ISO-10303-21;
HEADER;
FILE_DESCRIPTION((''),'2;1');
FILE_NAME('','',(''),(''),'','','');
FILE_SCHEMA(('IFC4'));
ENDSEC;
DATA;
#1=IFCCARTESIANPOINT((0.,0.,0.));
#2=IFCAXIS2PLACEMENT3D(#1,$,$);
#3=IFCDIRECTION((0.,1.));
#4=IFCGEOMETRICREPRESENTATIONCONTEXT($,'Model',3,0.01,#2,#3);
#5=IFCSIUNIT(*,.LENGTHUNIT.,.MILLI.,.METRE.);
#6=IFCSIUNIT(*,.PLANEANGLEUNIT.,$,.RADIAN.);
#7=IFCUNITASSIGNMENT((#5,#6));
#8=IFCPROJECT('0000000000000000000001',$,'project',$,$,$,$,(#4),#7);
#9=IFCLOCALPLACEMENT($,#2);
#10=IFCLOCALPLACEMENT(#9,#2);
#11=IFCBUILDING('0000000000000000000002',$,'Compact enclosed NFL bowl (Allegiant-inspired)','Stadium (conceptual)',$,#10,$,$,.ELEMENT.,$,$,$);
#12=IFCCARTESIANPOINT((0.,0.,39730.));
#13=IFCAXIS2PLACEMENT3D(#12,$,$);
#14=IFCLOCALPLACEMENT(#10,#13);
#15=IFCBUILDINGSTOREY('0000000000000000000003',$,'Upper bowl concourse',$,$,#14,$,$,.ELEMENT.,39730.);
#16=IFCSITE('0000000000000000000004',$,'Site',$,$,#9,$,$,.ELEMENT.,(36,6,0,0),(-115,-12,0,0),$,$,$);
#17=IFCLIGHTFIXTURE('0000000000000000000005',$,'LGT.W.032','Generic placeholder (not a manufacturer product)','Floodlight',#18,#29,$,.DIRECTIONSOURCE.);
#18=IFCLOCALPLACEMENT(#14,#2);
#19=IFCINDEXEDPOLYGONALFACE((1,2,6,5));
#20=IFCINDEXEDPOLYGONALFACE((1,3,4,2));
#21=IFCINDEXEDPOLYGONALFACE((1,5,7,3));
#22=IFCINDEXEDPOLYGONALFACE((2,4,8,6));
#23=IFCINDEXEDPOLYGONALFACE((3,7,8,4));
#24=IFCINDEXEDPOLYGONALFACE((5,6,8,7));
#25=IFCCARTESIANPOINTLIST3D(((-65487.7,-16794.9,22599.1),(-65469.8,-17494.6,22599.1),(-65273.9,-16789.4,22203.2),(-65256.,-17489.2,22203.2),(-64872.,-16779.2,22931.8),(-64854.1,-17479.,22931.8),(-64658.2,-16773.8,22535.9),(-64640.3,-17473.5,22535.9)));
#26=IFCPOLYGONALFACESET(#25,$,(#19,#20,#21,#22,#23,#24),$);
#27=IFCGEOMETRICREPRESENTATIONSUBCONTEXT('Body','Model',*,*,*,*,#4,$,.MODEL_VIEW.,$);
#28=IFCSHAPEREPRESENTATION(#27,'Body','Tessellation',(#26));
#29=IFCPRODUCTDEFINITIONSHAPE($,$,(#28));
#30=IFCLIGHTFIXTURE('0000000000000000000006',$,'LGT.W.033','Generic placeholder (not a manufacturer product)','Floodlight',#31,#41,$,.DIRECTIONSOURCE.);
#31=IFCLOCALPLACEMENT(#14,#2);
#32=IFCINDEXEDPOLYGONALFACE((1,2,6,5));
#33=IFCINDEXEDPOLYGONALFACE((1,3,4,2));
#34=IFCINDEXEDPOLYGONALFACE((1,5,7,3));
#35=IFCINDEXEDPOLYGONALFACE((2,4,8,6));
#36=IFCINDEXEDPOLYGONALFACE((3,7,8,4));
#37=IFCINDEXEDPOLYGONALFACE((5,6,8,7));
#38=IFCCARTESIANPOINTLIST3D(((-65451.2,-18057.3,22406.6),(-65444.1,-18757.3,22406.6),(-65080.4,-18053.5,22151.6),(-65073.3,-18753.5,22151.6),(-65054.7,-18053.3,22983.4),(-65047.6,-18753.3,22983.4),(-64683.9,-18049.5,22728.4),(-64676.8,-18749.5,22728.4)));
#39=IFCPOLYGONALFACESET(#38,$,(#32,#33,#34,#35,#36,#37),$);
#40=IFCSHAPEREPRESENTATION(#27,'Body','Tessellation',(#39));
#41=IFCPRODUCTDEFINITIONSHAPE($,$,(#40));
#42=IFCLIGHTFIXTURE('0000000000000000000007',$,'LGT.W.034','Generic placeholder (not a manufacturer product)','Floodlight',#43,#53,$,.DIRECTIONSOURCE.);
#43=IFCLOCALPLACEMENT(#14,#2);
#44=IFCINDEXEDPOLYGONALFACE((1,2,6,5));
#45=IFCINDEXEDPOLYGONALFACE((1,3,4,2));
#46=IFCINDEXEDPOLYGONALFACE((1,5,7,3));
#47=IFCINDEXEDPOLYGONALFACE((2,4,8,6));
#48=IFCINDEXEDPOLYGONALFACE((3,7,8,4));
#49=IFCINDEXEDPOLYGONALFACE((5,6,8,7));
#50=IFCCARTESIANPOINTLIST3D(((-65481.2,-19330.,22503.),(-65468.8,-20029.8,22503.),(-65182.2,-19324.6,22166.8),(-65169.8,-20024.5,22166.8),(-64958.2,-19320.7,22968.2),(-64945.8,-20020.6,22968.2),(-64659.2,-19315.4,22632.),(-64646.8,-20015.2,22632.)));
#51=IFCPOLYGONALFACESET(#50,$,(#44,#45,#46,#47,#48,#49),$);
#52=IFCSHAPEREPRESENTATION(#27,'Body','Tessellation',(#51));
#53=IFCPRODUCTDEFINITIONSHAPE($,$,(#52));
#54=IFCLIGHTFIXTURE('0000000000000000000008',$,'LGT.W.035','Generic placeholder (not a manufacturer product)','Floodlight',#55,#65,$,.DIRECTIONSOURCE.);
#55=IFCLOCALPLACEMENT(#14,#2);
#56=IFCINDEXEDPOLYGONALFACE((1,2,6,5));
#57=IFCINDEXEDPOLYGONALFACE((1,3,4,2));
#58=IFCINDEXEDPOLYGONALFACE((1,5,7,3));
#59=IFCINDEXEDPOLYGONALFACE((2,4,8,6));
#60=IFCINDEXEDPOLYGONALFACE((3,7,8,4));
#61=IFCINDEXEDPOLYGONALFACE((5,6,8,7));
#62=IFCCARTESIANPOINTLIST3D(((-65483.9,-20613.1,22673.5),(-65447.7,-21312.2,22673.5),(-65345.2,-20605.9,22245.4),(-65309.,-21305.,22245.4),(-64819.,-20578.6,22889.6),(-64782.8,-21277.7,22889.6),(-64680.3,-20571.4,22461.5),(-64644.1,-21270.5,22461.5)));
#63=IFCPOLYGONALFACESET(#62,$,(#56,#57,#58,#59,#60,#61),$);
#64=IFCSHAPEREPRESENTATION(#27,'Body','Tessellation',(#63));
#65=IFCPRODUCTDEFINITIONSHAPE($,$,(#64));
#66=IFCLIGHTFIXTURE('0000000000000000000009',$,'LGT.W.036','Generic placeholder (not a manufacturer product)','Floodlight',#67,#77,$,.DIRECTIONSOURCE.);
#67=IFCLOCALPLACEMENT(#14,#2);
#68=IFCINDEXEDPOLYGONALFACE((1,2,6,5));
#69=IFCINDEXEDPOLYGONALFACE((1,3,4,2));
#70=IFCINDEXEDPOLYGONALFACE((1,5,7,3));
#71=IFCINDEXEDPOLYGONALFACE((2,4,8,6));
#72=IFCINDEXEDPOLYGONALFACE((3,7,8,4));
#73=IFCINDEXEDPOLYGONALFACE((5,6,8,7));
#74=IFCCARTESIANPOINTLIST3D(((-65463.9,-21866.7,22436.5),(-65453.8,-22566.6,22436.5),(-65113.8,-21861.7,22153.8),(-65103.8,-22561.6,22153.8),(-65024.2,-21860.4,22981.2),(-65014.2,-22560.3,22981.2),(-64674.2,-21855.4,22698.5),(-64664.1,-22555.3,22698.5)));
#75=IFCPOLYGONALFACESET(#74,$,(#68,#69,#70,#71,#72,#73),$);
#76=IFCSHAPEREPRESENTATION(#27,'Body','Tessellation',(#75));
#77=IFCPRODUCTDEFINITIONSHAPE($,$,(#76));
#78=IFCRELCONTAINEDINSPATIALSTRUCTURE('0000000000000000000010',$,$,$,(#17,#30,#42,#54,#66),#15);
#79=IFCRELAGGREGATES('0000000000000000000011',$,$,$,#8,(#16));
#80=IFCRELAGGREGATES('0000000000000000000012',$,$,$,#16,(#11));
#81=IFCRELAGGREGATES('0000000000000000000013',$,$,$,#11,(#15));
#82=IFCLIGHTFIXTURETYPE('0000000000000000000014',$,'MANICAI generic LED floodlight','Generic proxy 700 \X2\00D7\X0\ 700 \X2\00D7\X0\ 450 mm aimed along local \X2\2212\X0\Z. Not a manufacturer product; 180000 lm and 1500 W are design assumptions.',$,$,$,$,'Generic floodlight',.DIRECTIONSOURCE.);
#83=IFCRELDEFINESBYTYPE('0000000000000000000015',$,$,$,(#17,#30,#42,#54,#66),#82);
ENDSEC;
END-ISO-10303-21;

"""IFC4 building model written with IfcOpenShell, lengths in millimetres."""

from ifc_helpers import new_model, si_unit, direction, frame, origin, place, context, subcontext, project, spatial, rectangle, extrude, source, transform, mapped, type_object, type_shapes, element, save


model = new_model("IFC4")

# Units and contexts
model_context = context("Model", 3, precision=0.01, world=origin(), true_north=direction((0.0, 1.0)))
body_context = subcontext(model_context, "Body", "Model", "MODEL_VIEW")
ifc_project = project(units=[si_unit("LENGTHUNIT", "METRE", prefix="MILLI"), si_unit("PLANEANGLEUNIT", "RADIAN")], contexts=[model_context])

# Site, building, storey
site_placement = place(None, origin())
site = spatial("IfcSite", under=ifc_project, at=site_placement, Name="Site", CompositionType="ELEMENT", RefLatitude=(36, 6, 0, 0), RefLongitude=(-115, -12, 0, 0))
building_placement = place(site_placement, origin())
building = spatial("IfcBuilding", under=site, at=building_placement, Name="Compact enclosed NFL bowl (Allegiant-inspired)", Description="Stadium (conceptual)", CompositionType="ELEMENT")
storey_placement = place(building_placement, frame((0.0, 0.0, 39730.0)))
storey = spatial("IfcBuildingStorey", under=building, at=storey_placement, Name="Upper bowl concourse", CompositionType="ELEMENT", Elevation=39730.0)

# Light fixtures
light_fixture_type = type_object("IfcLightFixtureType", Name="MANICAI generic LED floodlight", Description="Generic proxy 700 × 700 × 450 mm aimed along local −Z. Not a manufacturer product; 180000 lm and 1500 W are design assumptions.", ElementType="Generic floodlight", PredefinedType="DIRECTIONSOURCE")
shared_shape = source(origin(), body_context, "Body", "SweptSolid", [
    extrude(rectangle(XDim=700.0, YDim=700.0), frame((0.0, 0.0, -225.0)), (0.0, 0.0, 1.0), 450.0),
])
type_shapes(light_fixture_type, [shared_shape])
for number, where, z_axis, x_axis, name in (
    (1, (-65064.0, -17134.2, 22567.5), (-0.47509, -0.0121, 0.879854), (0.02546, -0.999676, 0.0), "LGT.W.032"),
    (2, (-65064.0, -18403.4, 22567.5), (-0.823981, -0.008368, 0.566555), (0.010155, -0.999948, 0.0), "LGT.W.033"),
    (3, (-65064.0, -19672.6, 22567.5), (-0.664463, -0.011798, 0.747228), (0.017753, -0.999842, 0.0), "LGT.W.034"),
    (4, (-65064.0, -20941.8, 22567.5), (-0.308275, -0.015987, 0.951163), (0.05179, -0.998658, 0.0), "LGT.W.035"),
    (5, (-65064.0, -22211.0, 22567.5), (-0.777995, -0.011198, 0.628171), (0.014392, -0.999896, 0.0), "LGT.W.036"),
):
    element("IfcLightFixture", number, at=place(storey_placement, frame(where, z_axis=z_axis, x_axis=x_axis)), inside=storey, type_object=light_fixture_type, Name=name, Description="Generic placeholder (not a manufacturer product)", ObjectType="Floodlight", PredefinedType="DIRECTIONSOURCE", context=body_context, shape_type="MappedRepresentation", body=[
        mapped(shared_shape, transform((0.0, 0.0, 0.0))),
    ])

save(model, "model.ifc")
